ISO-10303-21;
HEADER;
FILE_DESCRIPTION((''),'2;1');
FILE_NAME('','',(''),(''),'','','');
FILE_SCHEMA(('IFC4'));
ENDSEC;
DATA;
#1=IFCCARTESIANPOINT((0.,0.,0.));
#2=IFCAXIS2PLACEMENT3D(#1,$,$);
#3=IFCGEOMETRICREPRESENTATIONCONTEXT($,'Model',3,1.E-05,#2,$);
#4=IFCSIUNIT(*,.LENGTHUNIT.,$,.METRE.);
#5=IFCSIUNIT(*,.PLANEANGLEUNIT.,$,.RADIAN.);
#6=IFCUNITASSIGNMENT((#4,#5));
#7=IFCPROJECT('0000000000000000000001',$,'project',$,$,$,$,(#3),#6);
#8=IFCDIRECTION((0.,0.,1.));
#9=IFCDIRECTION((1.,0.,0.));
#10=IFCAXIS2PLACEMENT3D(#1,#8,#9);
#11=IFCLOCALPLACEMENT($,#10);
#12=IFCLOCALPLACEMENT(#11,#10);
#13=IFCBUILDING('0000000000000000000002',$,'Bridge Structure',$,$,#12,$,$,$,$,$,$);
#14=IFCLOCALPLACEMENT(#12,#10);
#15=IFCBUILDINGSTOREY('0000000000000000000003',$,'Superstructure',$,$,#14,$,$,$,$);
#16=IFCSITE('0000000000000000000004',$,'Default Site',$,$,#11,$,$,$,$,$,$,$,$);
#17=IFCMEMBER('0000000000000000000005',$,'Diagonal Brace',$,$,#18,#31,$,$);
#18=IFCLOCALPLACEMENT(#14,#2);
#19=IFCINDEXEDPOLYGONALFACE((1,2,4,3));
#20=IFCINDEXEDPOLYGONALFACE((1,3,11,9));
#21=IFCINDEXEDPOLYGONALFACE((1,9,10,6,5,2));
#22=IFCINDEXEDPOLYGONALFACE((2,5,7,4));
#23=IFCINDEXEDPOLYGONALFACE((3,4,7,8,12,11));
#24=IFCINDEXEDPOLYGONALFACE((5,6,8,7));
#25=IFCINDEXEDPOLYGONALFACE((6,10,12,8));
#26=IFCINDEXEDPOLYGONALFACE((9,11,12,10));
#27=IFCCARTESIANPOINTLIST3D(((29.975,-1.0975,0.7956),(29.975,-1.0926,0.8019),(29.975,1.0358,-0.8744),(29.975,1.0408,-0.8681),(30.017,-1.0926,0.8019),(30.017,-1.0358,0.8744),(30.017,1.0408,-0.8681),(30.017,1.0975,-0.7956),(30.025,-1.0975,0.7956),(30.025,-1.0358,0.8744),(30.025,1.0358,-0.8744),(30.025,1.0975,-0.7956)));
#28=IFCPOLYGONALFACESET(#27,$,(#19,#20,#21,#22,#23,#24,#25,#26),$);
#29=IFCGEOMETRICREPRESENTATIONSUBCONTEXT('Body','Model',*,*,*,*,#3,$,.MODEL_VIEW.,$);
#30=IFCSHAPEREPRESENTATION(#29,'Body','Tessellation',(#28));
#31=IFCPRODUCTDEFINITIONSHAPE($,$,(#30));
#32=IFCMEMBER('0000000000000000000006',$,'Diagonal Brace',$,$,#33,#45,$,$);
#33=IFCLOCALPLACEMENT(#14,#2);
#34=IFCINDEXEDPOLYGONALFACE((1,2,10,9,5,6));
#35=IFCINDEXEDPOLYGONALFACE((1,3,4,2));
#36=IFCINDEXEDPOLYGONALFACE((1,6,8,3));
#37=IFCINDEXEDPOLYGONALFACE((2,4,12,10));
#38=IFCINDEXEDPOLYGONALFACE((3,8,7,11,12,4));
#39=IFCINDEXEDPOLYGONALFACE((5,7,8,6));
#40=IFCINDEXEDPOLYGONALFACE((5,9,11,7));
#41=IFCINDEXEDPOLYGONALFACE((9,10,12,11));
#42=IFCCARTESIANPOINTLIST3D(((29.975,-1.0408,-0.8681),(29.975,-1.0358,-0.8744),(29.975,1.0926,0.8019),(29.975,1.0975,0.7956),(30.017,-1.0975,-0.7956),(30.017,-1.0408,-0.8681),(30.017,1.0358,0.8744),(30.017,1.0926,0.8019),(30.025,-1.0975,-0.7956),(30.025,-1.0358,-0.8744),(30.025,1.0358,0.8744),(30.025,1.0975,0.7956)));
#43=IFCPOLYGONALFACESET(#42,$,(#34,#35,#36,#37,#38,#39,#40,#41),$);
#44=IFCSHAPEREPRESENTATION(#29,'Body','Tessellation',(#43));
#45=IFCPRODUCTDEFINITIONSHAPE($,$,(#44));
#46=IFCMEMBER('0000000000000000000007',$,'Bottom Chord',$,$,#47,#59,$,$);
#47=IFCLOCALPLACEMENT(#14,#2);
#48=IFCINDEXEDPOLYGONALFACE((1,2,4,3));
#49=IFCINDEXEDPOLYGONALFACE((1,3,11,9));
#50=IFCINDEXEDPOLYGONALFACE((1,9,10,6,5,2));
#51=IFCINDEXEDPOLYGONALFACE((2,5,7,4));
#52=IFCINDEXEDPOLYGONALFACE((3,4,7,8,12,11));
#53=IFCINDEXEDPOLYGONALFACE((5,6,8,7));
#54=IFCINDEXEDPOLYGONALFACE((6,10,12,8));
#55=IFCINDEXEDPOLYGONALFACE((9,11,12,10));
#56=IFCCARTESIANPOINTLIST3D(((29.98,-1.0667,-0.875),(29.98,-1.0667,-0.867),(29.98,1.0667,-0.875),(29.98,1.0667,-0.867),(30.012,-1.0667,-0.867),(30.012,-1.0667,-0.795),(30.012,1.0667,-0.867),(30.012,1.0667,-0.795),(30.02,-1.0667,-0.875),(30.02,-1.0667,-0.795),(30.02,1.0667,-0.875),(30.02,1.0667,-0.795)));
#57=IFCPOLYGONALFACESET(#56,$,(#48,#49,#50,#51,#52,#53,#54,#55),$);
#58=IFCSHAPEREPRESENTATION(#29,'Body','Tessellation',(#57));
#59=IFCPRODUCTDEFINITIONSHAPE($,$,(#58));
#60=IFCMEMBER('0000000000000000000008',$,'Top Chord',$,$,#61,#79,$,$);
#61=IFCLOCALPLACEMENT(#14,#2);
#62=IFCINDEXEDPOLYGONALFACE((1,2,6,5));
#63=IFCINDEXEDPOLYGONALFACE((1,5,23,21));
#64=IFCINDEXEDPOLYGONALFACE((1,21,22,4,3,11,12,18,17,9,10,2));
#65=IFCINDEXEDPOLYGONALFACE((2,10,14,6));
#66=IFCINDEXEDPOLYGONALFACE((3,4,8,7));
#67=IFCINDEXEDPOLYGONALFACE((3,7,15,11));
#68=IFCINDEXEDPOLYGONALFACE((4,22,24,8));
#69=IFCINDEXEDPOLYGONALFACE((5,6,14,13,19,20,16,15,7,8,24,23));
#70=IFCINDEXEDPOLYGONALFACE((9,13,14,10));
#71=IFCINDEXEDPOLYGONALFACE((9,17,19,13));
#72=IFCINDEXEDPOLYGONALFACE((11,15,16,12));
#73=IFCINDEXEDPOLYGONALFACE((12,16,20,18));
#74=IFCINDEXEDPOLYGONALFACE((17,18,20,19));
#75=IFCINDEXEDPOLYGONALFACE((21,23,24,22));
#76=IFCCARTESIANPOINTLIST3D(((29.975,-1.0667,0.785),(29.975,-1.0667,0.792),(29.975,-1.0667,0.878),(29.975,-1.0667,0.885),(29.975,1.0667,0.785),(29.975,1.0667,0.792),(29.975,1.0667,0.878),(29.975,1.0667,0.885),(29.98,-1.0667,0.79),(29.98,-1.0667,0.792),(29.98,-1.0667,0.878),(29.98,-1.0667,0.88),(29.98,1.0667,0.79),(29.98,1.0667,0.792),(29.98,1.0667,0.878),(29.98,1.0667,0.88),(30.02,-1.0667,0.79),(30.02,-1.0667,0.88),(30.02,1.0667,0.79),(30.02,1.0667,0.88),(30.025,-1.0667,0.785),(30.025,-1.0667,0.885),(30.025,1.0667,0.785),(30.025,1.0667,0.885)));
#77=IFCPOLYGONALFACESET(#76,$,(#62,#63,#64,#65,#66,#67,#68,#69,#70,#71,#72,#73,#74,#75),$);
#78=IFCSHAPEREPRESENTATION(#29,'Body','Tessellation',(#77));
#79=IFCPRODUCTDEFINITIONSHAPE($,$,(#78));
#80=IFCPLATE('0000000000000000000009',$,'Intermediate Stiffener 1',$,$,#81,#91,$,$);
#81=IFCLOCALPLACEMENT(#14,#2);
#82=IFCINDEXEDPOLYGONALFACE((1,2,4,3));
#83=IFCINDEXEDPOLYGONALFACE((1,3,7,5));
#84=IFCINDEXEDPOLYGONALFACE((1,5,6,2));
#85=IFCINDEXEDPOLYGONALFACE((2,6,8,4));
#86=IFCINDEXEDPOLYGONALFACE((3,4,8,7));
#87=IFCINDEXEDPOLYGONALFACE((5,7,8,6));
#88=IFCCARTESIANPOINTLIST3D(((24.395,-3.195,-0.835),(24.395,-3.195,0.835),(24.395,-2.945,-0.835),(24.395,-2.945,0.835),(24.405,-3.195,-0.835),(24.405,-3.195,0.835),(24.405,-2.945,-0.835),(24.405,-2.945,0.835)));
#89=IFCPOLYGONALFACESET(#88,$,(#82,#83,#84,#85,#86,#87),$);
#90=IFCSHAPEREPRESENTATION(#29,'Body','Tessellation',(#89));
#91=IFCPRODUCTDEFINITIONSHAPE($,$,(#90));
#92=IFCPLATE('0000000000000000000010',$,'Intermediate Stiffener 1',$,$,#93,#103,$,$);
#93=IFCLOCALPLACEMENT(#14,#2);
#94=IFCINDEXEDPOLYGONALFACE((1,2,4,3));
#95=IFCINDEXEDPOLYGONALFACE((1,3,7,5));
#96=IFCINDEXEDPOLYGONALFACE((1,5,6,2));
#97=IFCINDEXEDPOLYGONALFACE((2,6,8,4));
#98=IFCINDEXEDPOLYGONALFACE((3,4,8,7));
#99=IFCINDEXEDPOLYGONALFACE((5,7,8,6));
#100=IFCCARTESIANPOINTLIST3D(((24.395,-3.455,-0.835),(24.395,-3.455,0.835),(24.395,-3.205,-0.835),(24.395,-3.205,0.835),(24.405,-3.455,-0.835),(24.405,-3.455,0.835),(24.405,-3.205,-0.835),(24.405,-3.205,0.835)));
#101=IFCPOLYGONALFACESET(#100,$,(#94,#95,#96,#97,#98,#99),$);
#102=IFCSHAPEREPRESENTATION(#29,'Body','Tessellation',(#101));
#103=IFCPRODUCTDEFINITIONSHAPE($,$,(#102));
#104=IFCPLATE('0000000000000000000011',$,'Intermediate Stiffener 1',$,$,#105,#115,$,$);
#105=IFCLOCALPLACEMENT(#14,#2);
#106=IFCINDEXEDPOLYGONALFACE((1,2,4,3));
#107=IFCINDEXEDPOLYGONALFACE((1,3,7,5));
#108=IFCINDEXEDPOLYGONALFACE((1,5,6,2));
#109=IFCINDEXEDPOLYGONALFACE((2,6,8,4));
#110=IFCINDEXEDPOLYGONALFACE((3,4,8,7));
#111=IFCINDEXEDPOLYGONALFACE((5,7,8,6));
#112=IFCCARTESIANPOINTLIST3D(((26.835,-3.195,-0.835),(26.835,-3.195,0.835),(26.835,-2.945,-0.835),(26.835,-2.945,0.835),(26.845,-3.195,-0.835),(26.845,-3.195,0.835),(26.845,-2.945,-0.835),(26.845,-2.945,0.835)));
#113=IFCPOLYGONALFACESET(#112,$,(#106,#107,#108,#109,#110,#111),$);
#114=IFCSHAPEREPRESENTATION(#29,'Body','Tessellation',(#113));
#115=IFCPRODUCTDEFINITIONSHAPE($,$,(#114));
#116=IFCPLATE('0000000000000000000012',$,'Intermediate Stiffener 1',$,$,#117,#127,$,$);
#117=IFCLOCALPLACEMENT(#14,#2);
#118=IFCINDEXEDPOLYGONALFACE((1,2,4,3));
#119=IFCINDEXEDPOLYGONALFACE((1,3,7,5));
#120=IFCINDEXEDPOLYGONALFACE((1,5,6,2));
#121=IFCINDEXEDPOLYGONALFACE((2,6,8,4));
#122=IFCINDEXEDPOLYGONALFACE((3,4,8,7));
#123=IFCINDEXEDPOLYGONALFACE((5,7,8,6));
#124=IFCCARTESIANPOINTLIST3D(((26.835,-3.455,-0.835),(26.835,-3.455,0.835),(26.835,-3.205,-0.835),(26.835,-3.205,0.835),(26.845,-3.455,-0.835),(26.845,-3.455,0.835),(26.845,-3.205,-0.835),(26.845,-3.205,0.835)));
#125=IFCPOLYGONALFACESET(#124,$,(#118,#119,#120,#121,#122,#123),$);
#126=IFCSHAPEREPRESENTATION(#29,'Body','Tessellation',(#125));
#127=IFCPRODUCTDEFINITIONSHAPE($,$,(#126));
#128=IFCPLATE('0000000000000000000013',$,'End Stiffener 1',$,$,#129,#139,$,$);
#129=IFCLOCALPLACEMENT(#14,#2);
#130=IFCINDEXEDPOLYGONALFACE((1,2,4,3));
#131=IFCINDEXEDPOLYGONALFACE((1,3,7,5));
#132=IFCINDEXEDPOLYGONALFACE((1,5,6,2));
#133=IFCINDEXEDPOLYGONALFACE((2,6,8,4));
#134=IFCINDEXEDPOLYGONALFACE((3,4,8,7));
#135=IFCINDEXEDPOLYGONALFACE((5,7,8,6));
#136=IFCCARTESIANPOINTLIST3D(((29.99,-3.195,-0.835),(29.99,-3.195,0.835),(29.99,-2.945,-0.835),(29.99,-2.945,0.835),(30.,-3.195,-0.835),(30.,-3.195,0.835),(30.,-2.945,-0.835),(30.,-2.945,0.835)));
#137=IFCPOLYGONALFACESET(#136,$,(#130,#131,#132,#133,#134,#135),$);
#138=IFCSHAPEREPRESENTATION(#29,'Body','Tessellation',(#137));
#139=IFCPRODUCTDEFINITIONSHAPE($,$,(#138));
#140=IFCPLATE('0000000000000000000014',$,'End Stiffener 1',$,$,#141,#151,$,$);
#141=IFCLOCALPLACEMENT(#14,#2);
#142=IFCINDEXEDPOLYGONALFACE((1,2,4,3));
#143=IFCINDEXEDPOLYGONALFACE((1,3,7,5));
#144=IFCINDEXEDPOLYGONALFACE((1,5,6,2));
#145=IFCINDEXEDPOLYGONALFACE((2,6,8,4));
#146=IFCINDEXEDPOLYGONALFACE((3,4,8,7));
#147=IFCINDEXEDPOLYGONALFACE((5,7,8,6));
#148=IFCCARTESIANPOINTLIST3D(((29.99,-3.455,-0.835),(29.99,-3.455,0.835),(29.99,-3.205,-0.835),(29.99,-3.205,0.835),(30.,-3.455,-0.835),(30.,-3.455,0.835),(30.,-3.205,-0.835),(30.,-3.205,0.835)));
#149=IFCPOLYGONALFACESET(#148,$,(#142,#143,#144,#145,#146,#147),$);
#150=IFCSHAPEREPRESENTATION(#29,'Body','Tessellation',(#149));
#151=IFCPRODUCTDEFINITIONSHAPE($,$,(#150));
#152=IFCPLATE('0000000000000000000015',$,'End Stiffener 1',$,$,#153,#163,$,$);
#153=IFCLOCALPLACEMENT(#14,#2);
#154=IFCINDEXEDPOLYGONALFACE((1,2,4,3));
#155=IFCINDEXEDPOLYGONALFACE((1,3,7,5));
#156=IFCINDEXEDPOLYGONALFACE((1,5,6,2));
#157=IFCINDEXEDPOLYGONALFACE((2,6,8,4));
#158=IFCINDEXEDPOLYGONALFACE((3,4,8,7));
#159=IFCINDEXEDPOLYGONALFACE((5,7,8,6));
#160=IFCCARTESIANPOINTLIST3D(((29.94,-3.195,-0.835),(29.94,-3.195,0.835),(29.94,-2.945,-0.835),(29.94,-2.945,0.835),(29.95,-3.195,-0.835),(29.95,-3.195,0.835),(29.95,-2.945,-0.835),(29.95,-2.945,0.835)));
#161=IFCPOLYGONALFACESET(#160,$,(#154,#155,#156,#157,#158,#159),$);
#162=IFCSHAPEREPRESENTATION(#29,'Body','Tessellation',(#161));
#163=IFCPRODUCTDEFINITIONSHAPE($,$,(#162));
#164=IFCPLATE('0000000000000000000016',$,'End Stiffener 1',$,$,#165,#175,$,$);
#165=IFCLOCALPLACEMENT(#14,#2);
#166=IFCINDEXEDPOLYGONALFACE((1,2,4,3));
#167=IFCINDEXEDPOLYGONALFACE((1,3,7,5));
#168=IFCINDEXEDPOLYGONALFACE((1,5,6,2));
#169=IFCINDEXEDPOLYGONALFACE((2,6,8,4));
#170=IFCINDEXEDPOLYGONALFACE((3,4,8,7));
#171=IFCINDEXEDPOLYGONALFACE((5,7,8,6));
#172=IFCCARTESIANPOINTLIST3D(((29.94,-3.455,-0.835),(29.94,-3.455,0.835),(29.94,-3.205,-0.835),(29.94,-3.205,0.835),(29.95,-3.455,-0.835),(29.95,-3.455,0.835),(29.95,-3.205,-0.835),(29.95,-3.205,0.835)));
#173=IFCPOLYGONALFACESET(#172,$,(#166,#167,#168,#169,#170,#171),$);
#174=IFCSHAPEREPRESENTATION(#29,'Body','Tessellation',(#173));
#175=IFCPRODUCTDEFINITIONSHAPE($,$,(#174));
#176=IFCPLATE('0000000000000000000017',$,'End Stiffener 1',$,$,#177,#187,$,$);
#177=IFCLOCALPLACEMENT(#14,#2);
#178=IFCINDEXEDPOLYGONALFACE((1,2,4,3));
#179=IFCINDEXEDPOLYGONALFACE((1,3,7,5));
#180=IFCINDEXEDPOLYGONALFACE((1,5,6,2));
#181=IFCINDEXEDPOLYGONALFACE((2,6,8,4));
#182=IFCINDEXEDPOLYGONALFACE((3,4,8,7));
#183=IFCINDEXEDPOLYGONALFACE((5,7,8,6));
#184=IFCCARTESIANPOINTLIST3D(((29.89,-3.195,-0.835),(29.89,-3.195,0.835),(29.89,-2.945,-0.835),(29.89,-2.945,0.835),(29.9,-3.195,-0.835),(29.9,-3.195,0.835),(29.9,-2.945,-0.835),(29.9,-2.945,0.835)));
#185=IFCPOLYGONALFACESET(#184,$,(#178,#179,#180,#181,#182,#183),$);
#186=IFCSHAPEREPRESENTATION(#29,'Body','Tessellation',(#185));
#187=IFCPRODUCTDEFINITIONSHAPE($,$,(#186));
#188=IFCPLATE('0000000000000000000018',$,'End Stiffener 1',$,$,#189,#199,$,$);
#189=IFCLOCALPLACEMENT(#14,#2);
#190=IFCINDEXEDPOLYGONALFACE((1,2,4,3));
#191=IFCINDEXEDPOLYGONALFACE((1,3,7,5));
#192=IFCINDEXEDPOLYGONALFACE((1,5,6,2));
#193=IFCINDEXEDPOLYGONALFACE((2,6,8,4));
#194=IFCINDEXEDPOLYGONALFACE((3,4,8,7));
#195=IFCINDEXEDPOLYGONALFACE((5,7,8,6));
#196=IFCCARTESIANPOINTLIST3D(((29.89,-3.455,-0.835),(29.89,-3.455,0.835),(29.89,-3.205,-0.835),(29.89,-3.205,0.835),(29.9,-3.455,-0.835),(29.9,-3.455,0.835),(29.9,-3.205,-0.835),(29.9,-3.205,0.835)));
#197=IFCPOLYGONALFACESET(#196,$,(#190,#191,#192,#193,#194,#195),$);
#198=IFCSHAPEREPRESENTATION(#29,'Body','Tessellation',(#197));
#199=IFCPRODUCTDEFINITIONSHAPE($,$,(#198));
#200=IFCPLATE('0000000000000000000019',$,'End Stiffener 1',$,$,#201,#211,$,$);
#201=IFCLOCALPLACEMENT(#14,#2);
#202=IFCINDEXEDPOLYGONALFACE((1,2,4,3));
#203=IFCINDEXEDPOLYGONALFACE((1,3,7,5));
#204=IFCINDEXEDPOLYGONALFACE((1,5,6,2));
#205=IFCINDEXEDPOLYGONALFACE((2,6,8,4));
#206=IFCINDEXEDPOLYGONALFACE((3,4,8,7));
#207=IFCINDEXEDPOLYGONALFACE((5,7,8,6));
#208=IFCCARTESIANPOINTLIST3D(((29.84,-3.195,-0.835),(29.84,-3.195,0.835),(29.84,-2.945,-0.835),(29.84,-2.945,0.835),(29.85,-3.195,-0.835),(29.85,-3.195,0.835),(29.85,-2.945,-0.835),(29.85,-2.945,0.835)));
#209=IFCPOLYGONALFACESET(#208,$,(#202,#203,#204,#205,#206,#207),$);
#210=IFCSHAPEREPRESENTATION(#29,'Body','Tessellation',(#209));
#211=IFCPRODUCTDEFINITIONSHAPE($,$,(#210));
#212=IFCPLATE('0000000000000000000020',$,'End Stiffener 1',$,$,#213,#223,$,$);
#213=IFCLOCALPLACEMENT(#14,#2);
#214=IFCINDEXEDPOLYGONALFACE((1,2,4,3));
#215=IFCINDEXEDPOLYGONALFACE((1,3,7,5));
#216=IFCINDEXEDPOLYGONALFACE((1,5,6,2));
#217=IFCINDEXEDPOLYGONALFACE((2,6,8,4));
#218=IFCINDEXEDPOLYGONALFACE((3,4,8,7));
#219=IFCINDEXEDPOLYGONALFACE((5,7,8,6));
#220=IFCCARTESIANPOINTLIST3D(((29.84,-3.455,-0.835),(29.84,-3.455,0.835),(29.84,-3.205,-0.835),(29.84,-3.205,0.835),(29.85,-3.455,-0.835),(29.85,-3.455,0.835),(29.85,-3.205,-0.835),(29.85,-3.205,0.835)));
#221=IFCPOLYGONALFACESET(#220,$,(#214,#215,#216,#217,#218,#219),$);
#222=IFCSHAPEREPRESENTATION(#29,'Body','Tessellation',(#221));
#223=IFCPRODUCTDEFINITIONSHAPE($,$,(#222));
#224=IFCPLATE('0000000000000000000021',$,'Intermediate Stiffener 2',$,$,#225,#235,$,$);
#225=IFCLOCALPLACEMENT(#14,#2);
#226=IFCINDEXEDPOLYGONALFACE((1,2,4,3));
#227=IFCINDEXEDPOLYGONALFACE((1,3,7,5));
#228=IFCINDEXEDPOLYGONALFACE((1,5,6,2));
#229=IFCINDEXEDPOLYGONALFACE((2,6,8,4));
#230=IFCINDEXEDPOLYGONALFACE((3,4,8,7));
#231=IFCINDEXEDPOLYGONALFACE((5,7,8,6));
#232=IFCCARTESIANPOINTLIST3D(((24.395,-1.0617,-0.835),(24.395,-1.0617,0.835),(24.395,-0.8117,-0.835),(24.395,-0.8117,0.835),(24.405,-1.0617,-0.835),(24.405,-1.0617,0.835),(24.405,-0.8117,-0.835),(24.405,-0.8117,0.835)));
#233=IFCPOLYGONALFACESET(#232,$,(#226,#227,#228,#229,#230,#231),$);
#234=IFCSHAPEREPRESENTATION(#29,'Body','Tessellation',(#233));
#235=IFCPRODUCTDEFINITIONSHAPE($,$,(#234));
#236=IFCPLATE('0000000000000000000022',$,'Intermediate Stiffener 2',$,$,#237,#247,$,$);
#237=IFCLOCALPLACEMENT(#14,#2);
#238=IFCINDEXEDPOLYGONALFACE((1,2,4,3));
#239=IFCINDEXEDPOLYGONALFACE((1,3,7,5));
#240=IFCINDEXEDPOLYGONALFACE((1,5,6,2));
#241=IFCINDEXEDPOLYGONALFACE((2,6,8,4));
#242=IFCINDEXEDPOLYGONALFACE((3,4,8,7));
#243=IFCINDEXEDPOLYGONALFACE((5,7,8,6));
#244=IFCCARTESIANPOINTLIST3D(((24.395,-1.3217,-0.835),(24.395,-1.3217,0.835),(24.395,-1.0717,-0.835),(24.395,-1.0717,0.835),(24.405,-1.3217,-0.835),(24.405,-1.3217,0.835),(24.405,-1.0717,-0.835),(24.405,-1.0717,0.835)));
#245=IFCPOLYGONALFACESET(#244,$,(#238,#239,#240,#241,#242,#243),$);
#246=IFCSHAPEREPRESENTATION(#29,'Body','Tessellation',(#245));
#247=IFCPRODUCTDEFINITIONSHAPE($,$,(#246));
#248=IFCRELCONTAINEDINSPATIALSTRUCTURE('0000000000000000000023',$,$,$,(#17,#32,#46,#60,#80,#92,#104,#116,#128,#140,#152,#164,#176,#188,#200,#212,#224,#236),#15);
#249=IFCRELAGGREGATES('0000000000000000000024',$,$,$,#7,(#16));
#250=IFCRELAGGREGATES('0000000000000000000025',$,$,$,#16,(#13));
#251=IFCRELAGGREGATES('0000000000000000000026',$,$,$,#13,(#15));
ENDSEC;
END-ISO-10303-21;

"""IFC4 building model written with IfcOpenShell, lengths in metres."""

from ifc_helpers import new_model, si_unit, frame, origin, origin_with_axes, origin_2d_with_axis, place, context, subcontext, project, spatial, rectangle, l_section, c_section, extrude, element, save


model = new_model("IFC4")

# Units and contexts
model_context = context("Model", 3, precision=1e-05, world=origin())
body_context = subcontext(model_context, "Body", "Model", "MODEL_VIEW")
ifc_project = project(units=[si_unit("LENGTHUNIT", "METRE"), si_unit("PLANEANGLEUNIT", "RADIAN")], contexts=[model_context])

# Site, building, storey
site_placement = place(None, origin_with_axes())
site = spatial("IfcSite", under=ifc_project, at=site_placement, Name="Default Site")
building_placement = place(site_placement, origin_with_axes())
building = spatial("IfcBuilding", under=site, at=building_placement, Name="Bridge Structure")
storey_placement = place(building_placement, origin_with_axes())
storey = spatial("IfcBuildingStorey", under=building, at=storey_placement, Name="Superstructure")

# Members
for number, where, z_axis, x_axis, name in (
    (1, (30.0, -1.0667, 0.835), (0.0, 0.787427, -0.616408), (-1.0, 0.0, 0.0), "Diagonal Brace"),
    (2, (30.0, -1.0667, -0.835), (0.0, 0.787427, 0.616408), (-1.0, 0.0, 0.0), "Diagonal Brace"),
):
    element("IfcMember", number, at=place(storey_placement, frame(where, z_axis=z_axis, x_axis=x_axis)), inside=storey, Name=name, context=body_context, shape_type="SweptSolid", body=[
        extrude(l_section(Depth=0.1, Width=0.05, Thickness=0.008, at=origin_2d_with_axis()), origin_with_axes(), (0.0, 0.0, 1.0), 2.7092),
    ])
member_1_placement = place(storey_placement, frame((30.0, -1.0667, -0.835), z_axis=(0.0, 1.0, 0.0), x_axis=(-1.0, 0.0, 0.0)))
element("IfcMember", 3, at=member_1_placement, inside=storey, Name="Bottom Chord", context=body_context, shape_type="SweptSolid", body=[
    extrude(l_section(Depth=0.08, Width=0.04, Thickness=0.008, at=origin_2d_with_axis()), origin_with_axes(), (0.0, 0.0, 1.0), 2.1333),
])
member_2_placement = place(storey_placement, frame((30.0, -1.0667, 0.835), z_axis=(0.0, 1.0, 0.0), x_axis=(-1.0, 0.0, 0.0)))
element("IfcMember", 4, at=member_2_placement, inside=storey, Name="Top Chord", context=body_context, shape_type="SweptSolid", body=[
    extrude(c_section(Depth=0.1, Width=0.05, WallThickness=0.005, Girth=0.007, at=origin_2d_with_axis()), origin_with_axes(), (0.0, 0.0, 1.0), 2.1333),
])

# Plates
for number, where, z_axis, x_axis, name in (
    (5, (24.4, -3.07, -0.835), (0.0, 0.0, 1.0), (1.0, 0.0, 0.0), "Intermediate Stiffener 1"),
    (6, (24.4, -3.33, -0.835), (0.0, 0.0, 1.0), (1.0, 0.0, 0.0), "Intermediate Stiffener 1"),
    (7, (26.84, -3.07, -0.835), (0.0, 0.0, 1.0), (1.0, 0.0, 0.0), "Intermediate Stiffener 1"),
    (8, (26.84, -3.33, -0.835), (0.0, 0.0, 1.0), (1.0, 0.0, 0.0), "Intermediate Stiffener 1"),
    (9, (29.995, -3.07, -0.835), (0.0, 0.0, 1.0), (1.0, 0.0, 0.0), "End Stiffener 1"),
    (10, (29.995, -3.33, -0.835), (0.0, 0.0, 1.0), (1.0, 0.0, 0.0), "End Stiffener 1"),
    (11, (29.945, -3.07, -0.835), (0.0, 0.0, 1.0), (1.0, 0.0, 0.0), "End Stiffener 1"),
    (12, (29.945, -3.33, -0.835), (0.0, 0.0, 1.0), (1.0, 0.0, 0.0), "End Stiffener 1"),
    (13, (29.895, -3.07, -0.835), (0.0, 0.0, 1.0), (1.0, 0.0, 0.0), "End Stiffener 1"),
    (14, (29.895, -3.33, -0.835), (0.0, 0.0, 1.0), (1.0, 0.0, 0.0), "End Stiffener 1"),
    (15, (29.845, -3.07, -0.835), (0.0, 0.0, 1.0), (1.0, 0.0, 0.0), "End Stiffener 1"),
    (16, (29.845, -3.33, -0.835), (0.0, 0.0, 1.0), (1.0, 0.0, 0.0), "End Stiffener 1"),
    (17, (24.4, -0.9367, -0.835), (0.0, 0.0, 1.0), (1.0, 0.0, 0.0), "Intermediate Stiffener 2"),
    (18, (24.4, -1.1967, -0.835), (0.0, 0.0, 1.0), (1.0, 0.0, 0.0), "Intermediate Stiffener 2"),
):
    element("IfcPlate", number, at=place(storey_placement, frame(where, z_axis=z_axis, x_axis=x_axis)), inside=storey, Name=name, context=body_context, shape_type="SweptSolid", body=[
        extrude(rectangle(XDim=0.01, YDim=0.25, at=origin_2d_with_axis()), origin_with_axes(), (0.0, 0.0, 1.0), 1.67),
    ])

save(model, "model.ifc")
